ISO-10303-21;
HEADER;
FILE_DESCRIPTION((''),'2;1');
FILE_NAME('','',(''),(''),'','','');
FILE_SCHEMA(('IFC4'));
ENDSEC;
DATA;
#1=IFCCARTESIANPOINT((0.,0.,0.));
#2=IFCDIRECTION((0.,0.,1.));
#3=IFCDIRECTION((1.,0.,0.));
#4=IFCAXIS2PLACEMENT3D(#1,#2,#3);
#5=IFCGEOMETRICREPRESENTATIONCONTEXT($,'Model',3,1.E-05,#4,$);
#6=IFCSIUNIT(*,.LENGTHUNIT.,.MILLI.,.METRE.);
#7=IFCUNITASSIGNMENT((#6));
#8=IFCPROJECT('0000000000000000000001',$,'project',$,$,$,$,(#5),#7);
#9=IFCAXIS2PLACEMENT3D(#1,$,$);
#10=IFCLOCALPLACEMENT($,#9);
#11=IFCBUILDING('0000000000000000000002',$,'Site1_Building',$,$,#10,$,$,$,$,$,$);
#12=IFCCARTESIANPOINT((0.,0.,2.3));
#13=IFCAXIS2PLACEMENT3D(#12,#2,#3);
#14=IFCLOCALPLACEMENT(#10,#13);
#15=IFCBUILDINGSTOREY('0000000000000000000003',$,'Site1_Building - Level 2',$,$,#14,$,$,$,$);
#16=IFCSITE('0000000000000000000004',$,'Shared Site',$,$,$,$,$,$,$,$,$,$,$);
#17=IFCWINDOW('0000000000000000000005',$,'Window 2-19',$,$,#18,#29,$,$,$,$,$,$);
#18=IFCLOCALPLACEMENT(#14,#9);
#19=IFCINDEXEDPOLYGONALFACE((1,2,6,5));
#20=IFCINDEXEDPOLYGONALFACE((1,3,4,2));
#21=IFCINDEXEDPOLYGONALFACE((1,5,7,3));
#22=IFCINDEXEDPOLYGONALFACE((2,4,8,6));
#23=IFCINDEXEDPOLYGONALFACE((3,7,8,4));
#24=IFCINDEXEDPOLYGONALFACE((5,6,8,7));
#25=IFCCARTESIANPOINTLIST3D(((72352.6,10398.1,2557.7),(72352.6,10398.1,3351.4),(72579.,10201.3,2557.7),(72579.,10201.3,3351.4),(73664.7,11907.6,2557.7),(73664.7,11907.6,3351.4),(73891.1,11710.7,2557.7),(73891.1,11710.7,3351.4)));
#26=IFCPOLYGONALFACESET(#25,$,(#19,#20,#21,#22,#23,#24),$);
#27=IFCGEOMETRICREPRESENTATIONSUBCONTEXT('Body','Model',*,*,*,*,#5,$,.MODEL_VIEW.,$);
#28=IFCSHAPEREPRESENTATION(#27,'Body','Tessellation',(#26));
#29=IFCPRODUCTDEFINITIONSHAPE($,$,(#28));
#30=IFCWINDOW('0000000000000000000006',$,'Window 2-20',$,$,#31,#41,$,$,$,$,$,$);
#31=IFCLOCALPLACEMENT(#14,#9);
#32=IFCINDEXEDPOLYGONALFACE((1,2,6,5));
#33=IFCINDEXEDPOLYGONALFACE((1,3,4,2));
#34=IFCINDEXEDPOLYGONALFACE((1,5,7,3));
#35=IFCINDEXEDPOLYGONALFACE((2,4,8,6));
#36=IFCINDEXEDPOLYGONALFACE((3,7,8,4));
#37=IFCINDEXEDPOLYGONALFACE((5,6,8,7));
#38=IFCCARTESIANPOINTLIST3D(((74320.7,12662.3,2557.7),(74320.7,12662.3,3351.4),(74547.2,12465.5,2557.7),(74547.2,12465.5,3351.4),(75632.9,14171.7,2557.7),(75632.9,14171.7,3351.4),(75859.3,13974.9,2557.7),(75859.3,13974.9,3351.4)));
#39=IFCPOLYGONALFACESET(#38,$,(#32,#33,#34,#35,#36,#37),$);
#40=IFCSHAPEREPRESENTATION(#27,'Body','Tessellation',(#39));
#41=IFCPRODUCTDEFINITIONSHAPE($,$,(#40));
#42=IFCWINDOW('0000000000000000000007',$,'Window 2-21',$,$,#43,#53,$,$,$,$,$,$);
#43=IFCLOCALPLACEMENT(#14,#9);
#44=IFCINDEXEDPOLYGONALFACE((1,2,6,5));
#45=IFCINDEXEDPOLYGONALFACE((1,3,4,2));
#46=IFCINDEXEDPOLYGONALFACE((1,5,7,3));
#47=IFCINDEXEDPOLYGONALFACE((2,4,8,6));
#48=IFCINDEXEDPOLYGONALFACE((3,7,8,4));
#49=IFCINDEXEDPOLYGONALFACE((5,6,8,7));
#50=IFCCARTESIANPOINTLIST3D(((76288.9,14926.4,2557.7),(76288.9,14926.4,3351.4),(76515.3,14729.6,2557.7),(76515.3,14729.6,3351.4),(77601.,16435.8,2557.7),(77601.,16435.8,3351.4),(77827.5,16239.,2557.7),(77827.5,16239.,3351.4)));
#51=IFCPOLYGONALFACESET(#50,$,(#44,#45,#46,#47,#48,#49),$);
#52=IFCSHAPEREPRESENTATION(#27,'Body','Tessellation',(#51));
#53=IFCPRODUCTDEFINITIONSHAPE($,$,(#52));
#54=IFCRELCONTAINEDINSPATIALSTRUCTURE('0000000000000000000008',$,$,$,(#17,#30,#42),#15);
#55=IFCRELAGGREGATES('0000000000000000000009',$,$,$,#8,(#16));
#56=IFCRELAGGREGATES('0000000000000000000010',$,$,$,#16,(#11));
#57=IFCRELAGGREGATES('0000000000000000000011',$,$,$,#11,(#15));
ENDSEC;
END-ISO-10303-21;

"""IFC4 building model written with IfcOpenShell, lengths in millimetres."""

from ifc_helpers import new_model, si_unit, frame, origin, origin_with_axes, place, context, subcontext, project, spatial, indexed_curve, outline, extrude, element, save


model = new_model("IFC4")

# Units and contexts
model_context = context("Model", 3, precision=1e-05, world=origin_with_axes())
body_context = subcontext(model_context, "Body", "Model", "MODEL_VIEW")
ifc_project = project(units=[si_unit("LENGTHUNIT", "METRE", prefix="MILLI")], contexts=[model_context])

# Site, building, storey
site = spatial("IfcSite", under=ifc_project, Name="Shared Site")
building_placement = place(None, origin())
building = spatial("IfcBuilding", under=site, at=building_placement, Name="Site1_Building")
storey_placement = place(building_placement, frame((0.0, 0.0, 2.3), z_axis=(0.0, 0.0, 1.0), x_axis=(1.0, 0.0, 0.0)))
storey = spatial("IfcBuildingStorey", under=building, at=storey_placement, Name="Site1_Building - Level 2")

# Windows
for number, where, z_axis, x_axis, name in (
    (1, (72579.0, 10201.3, 2557.7), (0.0, 0.0, 1.0), (0.656059, 0.75471, 0.0), "Window 2-19"),
    (2, (74547.2, 12465.5, 2557.7), (0.0, 0.0, 1.0), (0.656059, 0.75471, 0.0), "Window 2-20"),
    (3, (76515.3, 14729.6, 2557.7), (0.0, 0.0, 1.0), (0.656059, 0.75471, 0.0), "Window 2-21"),
):
    element("IfcWindow", number, at=place(storey_placement, frame(where, z_axis=z_axis, x_axis=x_axis)), inside=storey, Name=name, context=body_context, shape_type="SweptSolid", body=[
        extrude(outline(indexed_curve([(0.0, 0.0), (0.0, 300.0), (2000.0, 300.0), (2000.0, 0.0), (0.0, 0.0)], self_intersect=False)), origin_with_axes(), (0.0, 0.0, 1.0), 793.6),
    ])

save(model, "model.ifc")
